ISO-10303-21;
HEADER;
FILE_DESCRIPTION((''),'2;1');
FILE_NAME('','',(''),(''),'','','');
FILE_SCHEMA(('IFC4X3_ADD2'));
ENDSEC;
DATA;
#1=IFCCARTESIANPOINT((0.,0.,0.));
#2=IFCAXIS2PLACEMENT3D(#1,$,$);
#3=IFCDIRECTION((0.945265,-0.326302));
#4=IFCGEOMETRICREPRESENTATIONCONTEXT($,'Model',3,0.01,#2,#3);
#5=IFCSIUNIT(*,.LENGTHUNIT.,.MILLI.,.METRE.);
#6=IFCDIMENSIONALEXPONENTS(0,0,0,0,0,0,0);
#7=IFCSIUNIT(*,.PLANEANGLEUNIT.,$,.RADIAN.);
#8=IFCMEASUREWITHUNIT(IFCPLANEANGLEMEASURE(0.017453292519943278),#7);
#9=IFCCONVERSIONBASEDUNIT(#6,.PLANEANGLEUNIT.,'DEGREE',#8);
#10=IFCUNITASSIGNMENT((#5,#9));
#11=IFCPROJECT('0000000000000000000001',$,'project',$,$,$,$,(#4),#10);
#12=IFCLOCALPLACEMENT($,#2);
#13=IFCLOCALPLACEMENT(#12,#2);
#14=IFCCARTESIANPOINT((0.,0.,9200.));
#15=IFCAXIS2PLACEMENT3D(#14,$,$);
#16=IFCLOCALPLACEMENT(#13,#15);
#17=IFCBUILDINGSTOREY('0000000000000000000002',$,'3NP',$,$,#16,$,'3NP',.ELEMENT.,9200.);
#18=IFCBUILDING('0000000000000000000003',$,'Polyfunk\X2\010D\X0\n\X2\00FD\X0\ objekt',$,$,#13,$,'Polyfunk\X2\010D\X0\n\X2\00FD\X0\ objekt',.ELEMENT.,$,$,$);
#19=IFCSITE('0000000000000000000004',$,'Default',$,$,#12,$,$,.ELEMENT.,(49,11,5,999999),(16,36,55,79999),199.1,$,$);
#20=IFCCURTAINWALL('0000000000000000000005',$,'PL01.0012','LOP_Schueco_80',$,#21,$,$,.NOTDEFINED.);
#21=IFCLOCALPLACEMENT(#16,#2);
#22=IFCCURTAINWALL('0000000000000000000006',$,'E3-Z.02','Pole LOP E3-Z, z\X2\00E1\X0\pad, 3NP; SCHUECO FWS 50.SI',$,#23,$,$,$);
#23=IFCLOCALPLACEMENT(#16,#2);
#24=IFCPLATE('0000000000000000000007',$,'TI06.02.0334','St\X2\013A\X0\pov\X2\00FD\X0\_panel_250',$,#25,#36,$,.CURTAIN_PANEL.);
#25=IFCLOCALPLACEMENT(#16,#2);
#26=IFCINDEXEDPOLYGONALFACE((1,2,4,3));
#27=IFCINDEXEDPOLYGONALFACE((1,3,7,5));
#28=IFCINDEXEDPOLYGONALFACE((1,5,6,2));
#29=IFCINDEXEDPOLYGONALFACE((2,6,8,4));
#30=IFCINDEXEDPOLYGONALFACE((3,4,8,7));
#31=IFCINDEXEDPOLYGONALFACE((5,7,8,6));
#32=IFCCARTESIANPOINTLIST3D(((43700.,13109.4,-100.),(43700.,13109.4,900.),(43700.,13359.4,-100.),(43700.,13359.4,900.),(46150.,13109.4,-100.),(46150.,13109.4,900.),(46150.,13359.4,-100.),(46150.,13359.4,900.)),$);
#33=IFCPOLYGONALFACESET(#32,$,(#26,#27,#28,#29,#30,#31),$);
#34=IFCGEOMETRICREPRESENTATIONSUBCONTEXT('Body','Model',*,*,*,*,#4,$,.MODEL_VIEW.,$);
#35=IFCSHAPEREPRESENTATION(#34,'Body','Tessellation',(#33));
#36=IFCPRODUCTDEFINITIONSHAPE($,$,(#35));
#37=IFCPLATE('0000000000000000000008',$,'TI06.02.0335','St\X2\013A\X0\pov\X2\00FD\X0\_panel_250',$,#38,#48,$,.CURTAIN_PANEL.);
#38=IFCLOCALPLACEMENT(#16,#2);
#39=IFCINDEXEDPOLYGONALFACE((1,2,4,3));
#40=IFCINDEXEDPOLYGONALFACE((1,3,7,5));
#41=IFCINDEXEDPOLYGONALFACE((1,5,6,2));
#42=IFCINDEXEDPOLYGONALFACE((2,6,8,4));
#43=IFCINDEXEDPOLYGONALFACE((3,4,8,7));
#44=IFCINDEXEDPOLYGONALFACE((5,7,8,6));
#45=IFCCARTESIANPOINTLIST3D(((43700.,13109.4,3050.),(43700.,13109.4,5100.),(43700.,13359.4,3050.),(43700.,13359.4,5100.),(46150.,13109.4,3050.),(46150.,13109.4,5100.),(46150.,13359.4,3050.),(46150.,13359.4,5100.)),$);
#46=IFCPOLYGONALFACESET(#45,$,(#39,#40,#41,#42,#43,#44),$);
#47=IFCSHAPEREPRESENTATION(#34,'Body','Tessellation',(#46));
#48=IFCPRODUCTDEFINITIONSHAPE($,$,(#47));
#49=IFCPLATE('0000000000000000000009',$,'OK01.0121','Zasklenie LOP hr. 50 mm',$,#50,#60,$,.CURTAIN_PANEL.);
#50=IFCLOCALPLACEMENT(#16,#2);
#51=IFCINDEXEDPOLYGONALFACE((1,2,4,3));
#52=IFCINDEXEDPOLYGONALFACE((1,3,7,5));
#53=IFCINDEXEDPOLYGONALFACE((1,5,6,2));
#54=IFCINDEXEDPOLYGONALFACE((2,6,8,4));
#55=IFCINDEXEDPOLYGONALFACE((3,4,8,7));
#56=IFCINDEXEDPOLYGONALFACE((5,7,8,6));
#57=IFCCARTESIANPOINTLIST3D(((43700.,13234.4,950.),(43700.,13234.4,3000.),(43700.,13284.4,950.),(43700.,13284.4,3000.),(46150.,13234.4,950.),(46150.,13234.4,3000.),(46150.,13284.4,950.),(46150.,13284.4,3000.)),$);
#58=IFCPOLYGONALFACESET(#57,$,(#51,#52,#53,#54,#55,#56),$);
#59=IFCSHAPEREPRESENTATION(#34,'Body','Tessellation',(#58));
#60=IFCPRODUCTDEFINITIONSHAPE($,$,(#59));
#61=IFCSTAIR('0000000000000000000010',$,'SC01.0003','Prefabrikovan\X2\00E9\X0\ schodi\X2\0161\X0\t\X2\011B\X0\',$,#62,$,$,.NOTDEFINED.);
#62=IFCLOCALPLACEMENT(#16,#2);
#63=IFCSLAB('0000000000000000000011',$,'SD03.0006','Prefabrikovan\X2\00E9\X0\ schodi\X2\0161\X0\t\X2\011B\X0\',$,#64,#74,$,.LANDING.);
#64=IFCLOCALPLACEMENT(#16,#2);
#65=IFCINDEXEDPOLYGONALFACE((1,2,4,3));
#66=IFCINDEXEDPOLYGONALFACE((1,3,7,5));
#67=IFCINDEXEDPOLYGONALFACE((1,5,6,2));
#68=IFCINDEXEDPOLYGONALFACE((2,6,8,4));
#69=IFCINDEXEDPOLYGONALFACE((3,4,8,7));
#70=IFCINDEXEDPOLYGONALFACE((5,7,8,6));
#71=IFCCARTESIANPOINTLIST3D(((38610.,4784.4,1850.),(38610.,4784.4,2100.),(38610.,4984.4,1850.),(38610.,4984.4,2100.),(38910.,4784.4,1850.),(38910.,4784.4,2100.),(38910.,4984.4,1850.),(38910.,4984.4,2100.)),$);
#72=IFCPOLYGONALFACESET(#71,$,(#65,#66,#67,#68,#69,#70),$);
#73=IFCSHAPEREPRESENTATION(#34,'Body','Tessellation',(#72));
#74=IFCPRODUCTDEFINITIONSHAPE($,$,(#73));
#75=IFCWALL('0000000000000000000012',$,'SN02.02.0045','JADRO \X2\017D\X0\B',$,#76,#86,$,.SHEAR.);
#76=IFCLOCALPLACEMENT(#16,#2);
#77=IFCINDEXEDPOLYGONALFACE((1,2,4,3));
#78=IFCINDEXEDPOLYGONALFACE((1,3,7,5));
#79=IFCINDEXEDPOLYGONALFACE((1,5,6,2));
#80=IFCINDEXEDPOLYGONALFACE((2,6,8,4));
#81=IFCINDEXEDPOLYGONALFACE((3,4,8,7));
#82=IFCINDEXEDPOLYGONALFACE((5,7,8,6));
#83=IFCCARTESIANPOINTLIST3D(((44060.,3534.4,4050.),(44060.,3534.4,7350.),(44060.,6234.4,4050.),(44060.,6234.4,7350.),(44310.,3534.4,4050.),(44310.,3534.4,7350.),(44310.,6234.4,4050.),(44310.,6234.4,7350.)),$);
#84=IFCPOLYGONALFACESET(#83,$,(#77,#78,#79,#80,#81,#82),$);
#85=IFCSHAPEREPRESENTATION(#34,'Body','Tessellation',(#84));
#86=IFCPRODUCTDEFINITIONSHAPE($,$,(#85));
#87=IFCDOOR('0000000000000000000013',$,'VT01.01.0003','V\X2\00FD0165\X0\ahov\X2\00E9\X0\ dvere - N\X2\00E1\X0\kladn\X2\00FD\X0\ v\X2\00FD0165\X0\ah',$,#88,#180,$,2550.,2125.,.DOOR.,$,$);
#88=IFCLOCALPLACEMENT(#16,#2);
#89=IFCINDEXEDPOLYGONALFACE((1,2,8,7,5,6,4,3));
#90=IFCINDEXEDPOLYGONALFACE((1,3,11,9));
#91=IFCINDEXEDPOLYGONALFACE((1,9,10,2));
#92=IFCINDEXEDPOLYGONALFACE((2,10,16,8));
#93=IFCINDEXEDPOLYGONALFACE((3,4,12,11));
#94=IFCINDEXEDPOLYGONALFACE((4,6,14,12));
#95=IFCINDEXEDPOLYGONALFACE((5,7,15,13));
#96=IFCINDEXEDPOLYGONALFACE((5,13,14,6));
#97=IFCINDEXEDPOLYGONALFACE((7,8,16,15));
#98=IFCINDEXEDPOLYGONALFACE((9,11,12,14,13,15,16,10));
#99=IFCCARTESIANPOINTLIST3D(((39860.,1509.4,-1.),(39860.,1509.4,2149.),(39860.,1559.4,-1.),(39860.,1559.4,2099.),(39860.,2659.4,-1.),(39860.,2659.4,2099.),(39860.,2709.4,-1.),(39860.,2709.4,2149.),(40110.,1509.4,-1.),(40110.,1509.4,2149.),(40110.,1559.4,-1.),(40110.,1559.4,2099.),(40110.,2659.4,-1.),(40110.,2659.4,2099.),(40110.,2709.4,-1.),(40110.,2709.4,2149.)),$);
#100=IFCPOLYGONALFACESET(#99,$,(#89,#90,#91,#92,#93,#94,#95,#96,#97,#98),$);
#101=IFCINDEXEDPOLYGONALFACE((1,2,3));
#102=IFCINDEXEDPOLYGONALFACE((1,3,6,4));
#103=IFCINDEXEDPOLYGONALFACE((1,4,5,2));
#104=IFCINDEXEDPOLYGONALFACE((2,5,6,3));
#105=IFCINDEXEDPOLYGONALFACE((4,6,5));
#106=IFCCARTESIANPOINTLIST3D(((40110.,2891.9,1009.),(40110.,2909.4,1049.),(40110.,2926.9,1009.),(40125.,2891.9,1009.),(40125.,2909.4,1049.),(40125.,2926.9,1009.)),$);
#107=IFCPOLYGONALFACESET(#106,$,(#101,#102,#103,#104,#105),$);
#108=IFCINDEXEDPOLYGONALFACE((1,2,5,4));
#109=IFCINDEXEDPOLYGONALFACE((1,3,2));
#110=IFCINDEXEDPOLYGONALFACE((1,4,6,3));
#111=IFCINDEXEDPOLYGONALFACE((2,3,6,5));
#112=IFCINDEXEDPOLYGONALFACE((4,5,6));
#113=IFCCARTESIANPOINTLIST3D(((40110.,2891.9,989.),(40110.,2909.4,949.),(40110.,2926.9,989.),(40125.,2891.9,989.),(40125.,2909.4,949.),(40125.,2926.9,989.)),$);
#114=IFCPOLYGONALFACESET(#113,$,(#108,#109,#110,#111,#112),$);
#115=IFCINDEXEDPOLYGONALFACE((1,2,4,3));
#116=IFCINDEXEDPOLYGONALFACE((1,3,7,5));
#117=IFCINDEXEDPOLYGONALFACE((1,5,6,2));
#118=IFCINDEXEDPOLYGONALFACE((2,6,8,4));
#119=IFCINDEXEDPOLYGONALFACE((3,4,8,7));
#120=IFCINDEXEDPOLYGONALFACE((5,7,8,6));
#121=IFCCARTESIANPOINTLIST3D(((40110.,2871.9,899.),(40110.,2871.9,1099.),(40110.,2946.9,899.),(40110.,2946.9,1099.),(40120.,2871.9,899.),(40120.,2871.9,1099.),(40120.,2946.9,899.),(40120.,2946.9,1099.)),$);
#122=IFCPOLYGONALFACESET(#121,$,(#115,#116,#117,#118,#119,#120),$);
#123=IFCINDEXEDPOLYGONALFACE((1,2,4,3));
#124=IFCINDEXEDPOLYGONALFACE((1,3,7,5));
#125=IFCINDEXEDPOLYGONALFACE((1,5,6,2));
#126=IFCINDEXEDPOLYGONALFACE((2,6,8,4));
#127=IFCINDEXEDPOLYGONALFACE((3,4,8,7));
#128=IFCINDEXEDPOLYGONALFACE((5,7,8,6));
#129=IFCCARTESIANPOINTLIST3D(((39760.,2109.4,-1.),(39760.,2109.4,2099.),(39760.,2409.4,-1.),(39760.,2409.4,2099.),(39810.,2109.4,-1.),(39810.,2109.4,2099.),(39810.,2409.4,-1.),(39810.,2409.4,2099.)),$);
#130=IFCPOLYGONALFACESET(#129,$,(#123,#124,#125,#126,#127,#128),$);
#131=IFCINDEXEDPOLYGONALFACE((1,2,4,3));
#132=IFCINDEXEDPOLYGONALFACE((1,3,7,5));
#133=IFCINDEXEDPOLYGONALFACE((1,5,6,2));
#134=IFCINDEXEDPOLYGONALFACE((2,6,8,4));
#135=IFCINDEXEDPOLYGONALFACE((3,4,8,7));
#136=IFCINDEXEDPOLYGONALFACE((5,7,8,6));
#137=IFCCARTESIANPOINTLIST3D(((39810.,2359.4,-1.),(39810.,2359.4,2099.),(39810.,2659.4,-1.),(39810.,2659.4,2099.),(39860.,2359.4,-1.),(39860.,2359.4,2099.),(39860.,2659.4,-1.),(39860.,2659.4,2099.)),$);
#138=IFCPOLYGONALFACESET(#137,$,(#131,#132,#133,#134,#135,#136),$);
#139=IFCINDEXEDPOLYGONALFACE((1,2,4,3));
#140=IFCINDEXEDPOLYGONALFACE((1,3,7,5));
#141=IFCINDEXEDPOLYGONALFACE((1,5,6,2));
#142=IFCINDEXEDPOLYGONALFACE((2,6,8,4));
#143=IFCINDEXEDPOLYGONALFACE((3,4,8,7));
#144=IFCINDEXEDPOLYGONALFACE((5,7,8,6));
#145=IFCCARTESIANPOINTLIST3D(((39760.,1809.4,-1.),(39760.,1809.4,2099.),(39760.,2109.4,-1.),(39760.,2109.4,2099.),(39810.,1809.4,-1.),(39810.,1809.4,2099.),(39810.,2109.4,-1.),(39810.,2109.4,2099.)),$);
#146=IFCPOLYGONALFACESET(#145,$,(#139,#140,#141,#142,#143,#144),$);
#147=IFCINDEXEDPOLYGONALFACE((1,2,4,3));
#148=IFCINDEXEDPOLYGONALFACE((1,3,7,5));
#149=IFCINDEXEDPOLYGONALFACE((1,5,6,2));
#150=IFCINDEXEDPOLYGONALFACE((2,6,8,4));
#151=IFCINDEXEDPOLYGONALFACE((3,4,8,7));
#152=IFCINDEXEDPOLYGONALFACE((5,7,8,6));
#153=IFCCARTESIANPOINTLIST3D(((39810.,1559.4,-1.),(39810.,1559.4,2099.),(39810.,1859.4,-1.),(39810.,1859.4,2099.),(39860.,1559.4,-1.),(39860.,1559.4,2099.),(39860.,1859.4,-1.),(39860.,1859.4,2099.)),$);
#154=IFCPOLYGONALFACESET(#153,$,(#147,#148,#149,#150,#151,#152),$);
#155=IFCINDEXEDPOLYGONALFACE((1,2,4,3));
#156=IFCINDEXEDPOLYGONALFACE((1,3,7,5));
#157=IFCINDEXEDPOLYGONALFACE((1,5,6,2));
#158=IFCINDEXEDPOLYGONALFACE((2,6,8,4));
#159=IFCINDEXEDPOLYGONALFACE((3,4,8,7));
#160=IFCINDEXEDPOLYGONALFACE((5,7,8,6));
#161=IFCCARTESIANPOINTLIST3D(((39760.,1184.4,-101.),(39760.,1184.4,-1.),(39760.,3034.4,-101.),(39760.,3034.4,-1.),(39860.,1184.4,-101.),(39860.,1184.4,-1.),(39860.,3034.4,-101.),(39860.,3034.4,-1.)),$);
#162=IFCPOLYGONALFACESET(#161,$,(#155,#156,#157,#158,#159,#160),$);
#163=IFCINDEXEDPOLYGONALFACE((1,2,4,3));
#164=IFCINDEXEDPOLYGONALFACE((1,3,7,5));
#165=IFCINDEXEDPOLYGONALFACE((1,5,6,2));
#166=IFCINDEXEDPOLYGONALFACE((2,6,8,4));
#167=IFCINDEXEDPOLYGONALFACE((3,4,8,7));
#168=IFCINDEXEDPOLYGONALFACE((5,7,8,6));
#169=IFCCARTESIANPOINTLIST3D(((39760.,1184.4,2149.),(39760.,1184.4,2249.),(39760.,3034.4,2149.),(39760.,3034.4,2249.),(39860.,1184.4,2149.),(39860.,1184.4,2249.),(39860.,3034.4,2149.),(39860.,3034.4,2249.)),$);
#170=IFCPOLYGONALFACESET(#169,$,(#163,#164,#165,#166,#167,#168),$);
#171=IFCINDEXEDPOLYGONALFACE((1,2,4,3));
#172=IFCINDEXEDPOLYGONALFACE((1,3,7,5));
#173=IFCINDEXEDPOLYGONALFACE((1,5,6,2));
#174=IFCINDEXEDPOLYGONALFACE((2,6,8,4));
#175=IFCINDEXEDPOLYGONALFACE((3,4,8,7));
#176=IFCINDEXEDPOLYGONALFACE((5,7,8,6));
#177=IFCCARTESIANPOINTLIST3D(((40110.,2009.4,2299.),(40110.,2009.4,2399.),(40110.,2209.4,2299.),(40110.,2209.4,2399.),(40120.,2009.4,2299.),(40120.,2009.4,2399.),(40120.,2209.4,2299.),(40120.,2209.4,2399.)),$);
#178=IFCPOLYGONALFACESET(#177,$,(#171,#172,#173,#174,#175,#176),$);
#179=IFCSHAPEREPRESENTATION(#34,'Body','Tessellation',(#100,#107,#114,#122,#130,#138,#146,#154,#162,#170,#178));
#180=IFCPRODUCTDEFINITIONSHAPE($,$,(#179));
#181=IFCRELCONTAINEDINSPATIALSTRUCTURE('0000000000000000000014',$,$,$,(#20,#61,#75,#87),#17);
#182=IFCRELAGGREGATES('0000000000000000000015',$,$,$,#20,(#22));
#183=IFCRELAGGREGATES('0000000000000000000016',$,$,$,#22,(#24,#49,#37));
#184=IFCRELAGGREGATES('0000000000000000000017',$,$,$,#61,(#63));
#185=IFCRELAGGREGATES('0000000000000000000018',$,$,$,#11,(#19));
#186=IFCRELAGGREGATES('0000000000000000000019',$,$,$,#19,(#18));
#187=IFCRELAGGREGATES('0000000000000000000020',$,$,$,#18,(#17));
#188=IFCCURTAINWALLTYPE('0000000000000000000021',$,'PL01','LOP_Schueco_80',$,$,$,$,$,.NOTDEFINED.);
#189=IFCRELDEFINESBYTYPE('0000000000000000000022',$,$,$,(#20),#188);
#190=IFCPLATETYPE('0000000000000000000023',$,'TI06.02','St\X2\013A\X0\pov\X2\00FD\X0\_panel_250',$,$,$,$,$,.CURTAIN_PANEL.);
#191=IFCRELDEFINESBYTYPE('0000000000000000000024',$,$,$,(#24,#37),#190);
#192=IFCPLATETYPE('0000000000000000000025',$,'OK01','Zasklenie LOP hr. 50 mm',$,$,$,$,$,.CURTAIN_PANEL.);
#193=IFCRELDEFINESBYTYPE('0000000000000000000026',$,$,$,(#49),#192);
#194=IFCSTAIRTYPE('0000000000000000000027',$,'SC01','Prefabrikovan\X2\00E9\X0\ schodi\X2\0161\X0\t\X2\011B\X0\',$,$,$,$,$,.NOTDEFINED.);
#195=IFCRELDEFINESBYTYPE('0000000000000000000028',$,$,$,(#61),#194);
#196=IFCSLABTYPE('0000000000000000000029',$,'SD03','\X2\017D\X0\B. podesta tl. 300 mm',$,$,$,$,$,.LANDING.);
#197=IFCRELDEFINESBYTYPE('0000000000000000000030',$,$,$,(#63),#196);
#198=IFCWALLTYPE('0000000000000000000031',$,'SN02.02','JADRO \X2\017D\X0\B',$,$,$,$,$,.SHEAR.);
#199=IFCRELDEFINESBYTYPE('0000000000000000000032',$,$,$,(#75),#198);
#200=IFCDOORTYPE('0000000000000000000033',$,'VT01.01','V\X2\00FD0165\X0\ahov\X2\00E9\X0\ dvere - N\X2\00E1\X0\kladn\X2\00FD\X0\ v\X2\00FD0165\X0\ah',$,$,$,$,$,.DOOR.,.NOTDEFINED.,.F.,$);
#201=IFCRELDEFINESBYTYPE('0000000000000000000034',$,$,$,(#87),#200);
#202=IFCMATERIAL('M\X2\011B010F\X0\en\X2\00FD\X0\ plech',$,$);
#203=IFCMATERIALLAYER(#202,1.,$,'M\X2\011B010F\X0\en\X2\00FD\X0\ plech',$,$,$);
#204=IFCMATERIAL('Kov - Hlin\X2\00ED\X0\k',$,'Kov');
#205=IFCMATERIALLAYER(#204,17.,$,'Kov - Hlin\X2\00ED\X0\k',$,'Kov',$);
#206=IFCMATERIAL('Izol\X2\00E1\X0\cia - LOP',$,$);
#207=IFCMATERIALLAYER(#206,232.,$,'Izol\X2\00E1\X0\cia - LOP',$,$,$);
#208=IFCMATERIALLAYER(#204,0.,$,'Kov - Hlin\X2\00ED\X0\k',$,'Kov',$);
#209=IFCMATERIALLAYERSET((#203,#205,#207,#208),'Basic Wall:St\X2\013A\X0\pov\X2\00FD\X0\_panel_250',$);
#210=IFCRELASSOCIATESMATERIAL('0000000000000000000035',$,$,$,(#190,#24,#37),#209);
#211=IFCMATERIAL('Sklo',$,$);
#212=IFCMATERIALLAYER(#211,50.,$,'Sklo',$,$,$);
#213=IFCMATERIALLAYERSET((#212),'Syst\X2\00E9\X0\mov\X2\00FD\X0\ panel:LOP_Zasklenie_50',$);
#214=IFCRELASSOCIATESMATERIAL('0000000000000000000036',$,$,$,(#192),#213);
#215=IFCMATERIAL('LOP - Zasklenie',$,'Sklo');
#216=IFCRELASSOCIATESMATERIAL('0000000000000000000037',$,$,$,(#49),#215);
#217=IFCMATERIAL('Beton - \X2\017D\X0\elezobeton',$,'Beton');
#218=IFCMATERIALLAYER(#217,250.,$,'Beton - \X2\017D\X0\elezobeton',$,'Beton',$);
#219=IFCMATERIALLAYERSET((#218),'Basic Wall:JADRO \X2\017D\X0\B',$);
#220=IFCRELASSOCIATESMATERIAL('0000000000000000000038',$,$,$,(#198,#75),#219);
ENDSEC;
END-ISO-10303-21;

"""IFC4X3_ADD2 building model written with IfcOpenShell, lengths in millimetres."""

from ifc_helpers import new_model, entity, si_unit, converted_unit, direction, frame, frame_2d, origin, origin_2d_with_axis, place, context, subcontext, project, spatial, polyline, rectangle, outline, extrude, clip, bounded_halfspace, source, transform, mapped, material, layer, layer_set, layer_usage, type_object, type_shapes, element, aggregate, save


model = new_model("IFC4X3_ADD2")

# Units and contexts
model_context = context("Model", 3, precision=0.01, world=origin(), true_north=direction((0.945265, -0.326302)))
body_context = subcontext(model_context, "Body", "Model", "MODEL_VIEW")
ifc_project = project(units=[si_unit("LENGTHUNIT", "METRE", prefix="MILLI"), converted_unit("PLANEANGLEUNIT", "DEGREE", entity("IfcPlaneAngleMeasure", 0.017453292519943278), si_unit("PLANEANGLEUNIT", "RADIAN"), dimensions=[0, 0, 0, 0, 0, 0, 0])], contexts=[model_context])

# Site, building, storey
site_placement = place(None, origin())
site = spatial("IfcSite", under=ifc_project, at=site_placement, Name="Default", CompositionType="ELEMENT", RefLatitude=(49, 11, 5, 999999), RefLongitude=(16, 36, 55, 79999), RefElevation=199.1)
building_placement = place(site_placement, origin())
building = spatial("IfcBuilding", under=site, at=building_placement, Name="Polyfunkčný objekt", LongName="Polyfunkčný objekt", CompositionType="ELEMENT")
storey_placement = place(building_placement, frame((0.0, 0.0, 9200.0)))
storey = spatial("IfcBuildingStorey", under=building, at=storey_placement, Name="3NP", LongName="3NP", CompositionType="ELEMENT", Elevation=9200.0)

# Curtain walls, plates
curtain_wall_type = type_object("IfcCurtainWallType", Name="PL01", Description="LOP_Schueco_80", PredefinedType="NOTDEFINED")
curtain_wall_1_placement = place(storey_placement, frame((0.0, 0.0, -9200.0)))
curtain_wall_1 = element("IfcCurtainWall", 1, at=curtain_wall_1_placement, inside=storey, type_object=curtain_wall_type, Name="PL01.0012", Description="LOP_Schueco_80", PredefinedType="NOTDEFINED")
curtain_wall_2 = element("IfcCurtainWall", 2, Name="E3-Z.02", Description="Pole LOP E3-Z, západ, 3NP; SCHUECO FWS 50.SI")
aggregate(curtain_wall_1, [curtain_wall_2])
ifc_material_1 = material(Name="Měďený plech")
ifc_layer_1 = layer(ifc_material_1, 1.0, Name="Měďený plech")
ifc_material_2 = material(Name="Kov - Hliník", Category="Kov")
ifc_layer_2 = layer(ifc_material_2, 17.0, Name="Kov - Hliník", Category="Kov")
ifc_material_3 = material(Name="Izolácia - LOP")
ifc_layer_3 = layer(ifc_material_3, 232.0, Name="Izolácia - LOP")
ifc_layer_4 = layer(ifc_material_2, 0.0, Name="Kov - Hliník", Category="Kov")
ifc_layer_set_1 = layer_set([ifc_layer_1, ifc_layer_2, ifc_layer_3, ifc_layer_4], Name="Basic Wall:Stĺpový_panel_250")
ifc_layer_usage_1 = layer_usage(ifc_layer_set_1, "AXIS2", "NEGATIVE", 125.0)
plate_type_1 = type_object("IfcPlateType", Name="TI06.02", Description="Stĺpový_panel_250", PredefinedType="CURTAIN_PANEL", material=ifc_layer_set_1)
plate_1_placement = place(storey_placement, frame((43700.0, 13234.4, -100.0)))
plate_1 = element("IfcPlate", 3, at=plate_1_placement, type_object=plate_type_1, material=ifc_layer_usage_1, Name="TI06.02.0334", Description="Stĺpový_panel_250", PredefinedType="CURTAIN_PANEL", context=body_context, shape_type="SweptSolid", body=[
    extrude(rectangle(XDim=250.0, YDim=2450.0, at=frame_2d((0.0, 0.0), x_axis=(1.0, 0.0))), frame((1225.0, 0.0, 0.0), z_axis=(0.0, 0.0, 1.0), x_axis=(0.0, 1.0, 0.0)), (0.0, 0.0, 1.0), 1000.0),
])
ifc_layer_usage_2 = layer_usage(ifc_layer_set_1, "AXIS2", "NEGATIVE", 125.0)
plate_2_placement = place(storey_placement, frame((43700.0, 13234.4, 3050.0)))
plate_2 = element("IfcPlate", 4, at=plate_2_placement, type_object=plate_type_1, material=ifc_layer_usage_2, Name="TI06.02.0335", Description="Stĺpový_panel_250", PredefinedType="CURTAIN_PANEL", context=body_context, shape_type="SweptSolid", body=[
    extrude(rectangle(XDim=250.0, YDim=2450.0, at=frame_2d((0.0, 0.0), x_axis=(1.0, 0.0))), frame((1225.0, 0.0, 0.0), z_axis=(0.0, 0.0, 1.0), x_axis=(0.0, 1.0, 0.0)), (0.0, 0.0, 1.0), 2050.0),
])
ifc_material_4 = material(Name="LOP - Zasklenie", Category="Sklo")
ifc_material_5 = material(Name="Sklo")
ifc_layer_5 = layer(ifc_material_5, 50.0, Name="Sklo")
ifc_layer_set_2 = layer_set([ifc_layer_5], Name="Systémový panel:LOP_Zasklenie_50")
plate_type_2 = type_object("IfcPlateType", Name="OK01", Description="Zasklenie LOP hr. 50 mm", PredefinedType="CURTAIN_PANEL", material=ifc_layer_set_2)
shared_shape_1 = source(origin(), body_context, "Body", "SweptSolid", [
    extrude(rectangle(XDim=50.0, YDim=2450.0, at=origin_2d_with_axis()), frame((0.0, 25.0, 0.0), z_axis=(0.0, 0.0, 1.0), x_axis=(0.0, 1.0, 0.0)), (0.0, 0.0, 1.0), 2050.0),
])
type_shapes(plate_type_2, [shared_shape_1])
plate_3_placement = place(curtain_wall_1_placement, frame((44925.0, 13234.4, 10150.0)))
plate_3 = element("IfcPlate", 5, at=plate_3_placement, type_object=plate_type_2, material=ifc_material_4, Name="OK01.0121", Description="Zasklenie LOP hr. 50 mm", PredefinedType="CURTAIN_PANEL", context=body_context, shape_type="MappedRepresentation", body=[
    mapped(shared_shape_1, transform((0.0, 0.0, 0.0), scale=1.0)),
])
aggregate(curtain_wall_2, [plate_1, plate_3, plate_2])

# Stair, slab
stair_type = type_object("IfcStairType", Name="SC01", Description="Prefabrikované schodiště", PredefinedType="NOTDEFINED")
stair_placement = place(storey_placement, origin())
stair = element("IfcStair", 6, at=stair_placement, inside=storey, type_object=stair_type, Name="SC01.0003", Description="Prefabrikované schodiště", PredefinedType="NOTDEFINED")
slab_type = type_object("IfcSlabType", Name="SD03", Description="ŽB. podesta tl. 300 mm", PredefinedType="LANDING")
slab_placement = place(stair_placement, frame((38610.0, 4784.4, 0.0)))
slab = element("IfcSlab", 7, at=slab_placement, type_object=slab_type, Name="SD03.0006", Description="Prefabrikované schodiště", PredefinedType="LANDING", context=body_context, shape_type="SweptSolid", body=[
    extrude(rectangle(XDim=200.0, YDim=300.0, at=frame_2d((0.0, 0.0), x_axis=(1.0, 0.0))), frame((150.0, 100.0, 1850.0), z_axis=(0.0, 0.0, 1.0), x_axis=(0.0, 1.0, 0.0)), (0.0, 0.0, 1.0), 250.0),
])
aggregate(stair, [slab])

# Wall
ifc_material_6 = material(Name="Beton - Železobeton", Category="Beton")
ifc_layer_6 = layer(ifc_material_6, 250.0, Name="Beton - Železobeton", Category="Beton")
ifc_layer_set_3 = layer_set([ifc_layer_6], Name="Basic Wall:JADRO ŽB")
wall_type = type_object("IfcWallType", Name="SN02.02", Description="JADRO ŽB", PredefinedType="SHEAR", material=ifc_layer_set_3)
wall_placement = place(storey_placement, frame((44185.0, 6234.4, 4050.0), z_axis=(0.0, 0.0, 1.0), x_axis=(0.0, -1.0, 0.0)))
element("IfcWall", 8, at=wall_placement, inside=storey, type_object=wall_type, material=ifc_layer_set_3, Name="SN02.02.0045", Description="JADRO ŽB", PredefinedType="SHEAR", context=body_context, shape_type="Clipping", body=[
    clip(clip(extrude(rectangle(XDim=2700.0, YDim=250.0, at=frame_2d((1350.0, 0.0), x_axis=(-1.0, 0.0))), origin(), (0.0, 0.0, 1.0), 3300.0), bounded_halfspace(frame((2700.0, -125.0, 0.0), z_axis=(0.0, 0.0, 1.0), x_axis=(0.0, -1.0, 0.0)), True, frame((2700.0, -125.0, 0.0)), polyline([(0.0, 0.0), (0.0, 250.0), (-2700.0, 250.0), (-2700.0, 0.0), (0.0, 0.0)]))), bounded_halfspace(frame((0.0, -125.0, 3300.0), z_axis=(0.0, 0.0, -1.0), x_axis=(1.0, 0.0, 0.0)), True, frame((0.0, -125.0, 3300.0)), polyline([(0.0, 0.0), (2700.0, 0.0), (2700.0, 250.0), (0.0, 250.0), (0.0, 0.0)]))),
])

# Door
door_type_1 = type_object("IfcDoorType", Name="VT01.01", Description="Výťahové dvere - Nákladný výťah", OperationType="NOTDEFINED", ParameterTakesPrecedence=False, PredefinedType="DOOR")
shared_shape_2 = source(origin(), body_context, "Body", "SweptSolid", [
    extrude(outline(polyline([(-1087.5, -600.0), (1062.5, -600.0), (1062.5, -550.0), (-1037.5, -550.0), (-1037.5, 550.0), (1062.5, 550.0), (1062.5, 600.0), (-1087.5, 600.0), (-1087.5, -600.0)])), frame((600.0, 0.0, 1062.5), z_axis=(0.0, 1.0, 0.0), x_axis=(0.0, 0.0, -1.0)), (0.0, 0.0, 1.0), 250.0),
    extrude(outline(polyline([(-24.4, -10.7), (19.2, -10.7), (5.2, 21.4), (-24.4, -10.7)])), frame((1400.0, -15.0, 1023.3), z_axis=(0.0, 1.0, 0.0), x_axis=(0.400819, 0.0, -0.916157)), (0.0, 0.0, 1.0), 15.0),
    extrude(outline(polyline([(-24.4, -10.7), (19.2, -10.7), (5.2, 21.4), (-24.4, -10.7)])), frame((1400.0, -15.0, 976.7), z_axis=(0.0, 1.0, 0.0), x_axis=(-0.400819, 0.0, 0.916157)), (0.0, 0.0, 1.0), 15.0),
    extrude(rectangle(XDim=10.0, YDim=75.0, at=frame_2d((0.0, 0.0), x_axis=(1.0, 0.0))), frame((1400.0, -5.0, 900.0), z_axis=(0.0, 0.0, 1.0), x_axis=(0.0, 1.0, 0.0)), (0.0, 0.0, 1.0), 200.0),
    extrude(rectangle(XDim=50.0, YDim=300.0, at=origin_2d_with_axis()), frame((750.0, 325.0, 0.0), z_axis=(0.0, 0.0, 1.0), x_axis=(0.0, -1.0, 0.0)), (0.0, 0.0, 1.0), 2100.0),
    extrude(rectangle(XDim=50.0, YDim=300.0, at=frame_2d((0.0, 0.0), x_axis=(1.0, 0.0))), frame((1000.0, 275.0, 0.0), z_axis=(0.0, 0.0, 1.0), x_axis=(0.0, -1.0, 0.0)), (0.0, 0.0, 1.0), 2100.0),
    extrude(rectangle(XDim=300.0, YDim=50.0, at=frame_2d((0.0, 0.0), x_axis=(1.0, 0.0))), frame((450.0, 325.0, 0.0), z_axis=(0.0, 0.0, 1.0), x_axis=(-1.0, 0.0, 0.0)), (0.0, 0.0, 1.0), 2100.0),
    extrude(rectangle(XDim=300.0, YDim=50.0, at=frame_2d((0.0, 0.0), x_axis=(1.0, 0.0))), frame((200.0, 275.0, 0.0), z_axis=(0.0, 0.0, 1.0), x_axis=(-1.0, 0.0, 0.0)), (0.0, 0.0, 1.0), 2100.0),
    extrude(rectangle(XDim=1850.0, YDim=100.0, at=frame_2d((0.0, 0.0), x_axis=(1.0, 0.0))), frame((600.0, 300.0, -100.0), z_axis=(0.0, 0.0, 1.0), x_axis=(-1.0, 0.0, 0.0)), (0.0, 0.0, 1.0), 100.0),
    extrude(rectangle(XDim=1850.0, YDim=100.0, at=frame_2d((0.0, 0.0), x_axis=(1.0, 0.0))), frame((600.0, 300.0, 2150.0), z_axis=(0.0, 0.0, 1.0), x_axis=(-1.0, 0.0, 0.0)), (0.0, 0.0, 1.0), 100.0),
    extrude(rectangle(XDim=10.0, YDim=200.0, at=frame_2d((0.0, 0.0), x_axis=(1.0, 0.0))), frame((600.0, -5.0, 2300.0), z_axis=(0.0, 0.0, 1.0), x_axis=(0.0, 1.0, 0.0)), (0.0, 0.0, 1.0), 100.0),
])
type_shapes(door_type_1, [shared_shape_2])
door_1_placement = place(storey_placement, frame((40110.0, 1509.4, -1.0), z_axis=(0.0, 0.0, 1.0), x_axis=(0.0, 1.0, 0.0)))
element("IfcDoor", 9, at=door_1_placement, inside=storey, type_object=door_type_1, Name="VT01.01.0003", Description="Výťahové dvere - Nákladný výťah", OverallHeight=2550.0, OverallWidth=2125.0, PredefinedType="DOOR", context=body_context, shape_type="MappedRepresentation", body=[
    mapped(shared_shape_2, transform((0.0, 0.0, 0.0), scale=1.0)),
])

save(model, "model.ifc")
